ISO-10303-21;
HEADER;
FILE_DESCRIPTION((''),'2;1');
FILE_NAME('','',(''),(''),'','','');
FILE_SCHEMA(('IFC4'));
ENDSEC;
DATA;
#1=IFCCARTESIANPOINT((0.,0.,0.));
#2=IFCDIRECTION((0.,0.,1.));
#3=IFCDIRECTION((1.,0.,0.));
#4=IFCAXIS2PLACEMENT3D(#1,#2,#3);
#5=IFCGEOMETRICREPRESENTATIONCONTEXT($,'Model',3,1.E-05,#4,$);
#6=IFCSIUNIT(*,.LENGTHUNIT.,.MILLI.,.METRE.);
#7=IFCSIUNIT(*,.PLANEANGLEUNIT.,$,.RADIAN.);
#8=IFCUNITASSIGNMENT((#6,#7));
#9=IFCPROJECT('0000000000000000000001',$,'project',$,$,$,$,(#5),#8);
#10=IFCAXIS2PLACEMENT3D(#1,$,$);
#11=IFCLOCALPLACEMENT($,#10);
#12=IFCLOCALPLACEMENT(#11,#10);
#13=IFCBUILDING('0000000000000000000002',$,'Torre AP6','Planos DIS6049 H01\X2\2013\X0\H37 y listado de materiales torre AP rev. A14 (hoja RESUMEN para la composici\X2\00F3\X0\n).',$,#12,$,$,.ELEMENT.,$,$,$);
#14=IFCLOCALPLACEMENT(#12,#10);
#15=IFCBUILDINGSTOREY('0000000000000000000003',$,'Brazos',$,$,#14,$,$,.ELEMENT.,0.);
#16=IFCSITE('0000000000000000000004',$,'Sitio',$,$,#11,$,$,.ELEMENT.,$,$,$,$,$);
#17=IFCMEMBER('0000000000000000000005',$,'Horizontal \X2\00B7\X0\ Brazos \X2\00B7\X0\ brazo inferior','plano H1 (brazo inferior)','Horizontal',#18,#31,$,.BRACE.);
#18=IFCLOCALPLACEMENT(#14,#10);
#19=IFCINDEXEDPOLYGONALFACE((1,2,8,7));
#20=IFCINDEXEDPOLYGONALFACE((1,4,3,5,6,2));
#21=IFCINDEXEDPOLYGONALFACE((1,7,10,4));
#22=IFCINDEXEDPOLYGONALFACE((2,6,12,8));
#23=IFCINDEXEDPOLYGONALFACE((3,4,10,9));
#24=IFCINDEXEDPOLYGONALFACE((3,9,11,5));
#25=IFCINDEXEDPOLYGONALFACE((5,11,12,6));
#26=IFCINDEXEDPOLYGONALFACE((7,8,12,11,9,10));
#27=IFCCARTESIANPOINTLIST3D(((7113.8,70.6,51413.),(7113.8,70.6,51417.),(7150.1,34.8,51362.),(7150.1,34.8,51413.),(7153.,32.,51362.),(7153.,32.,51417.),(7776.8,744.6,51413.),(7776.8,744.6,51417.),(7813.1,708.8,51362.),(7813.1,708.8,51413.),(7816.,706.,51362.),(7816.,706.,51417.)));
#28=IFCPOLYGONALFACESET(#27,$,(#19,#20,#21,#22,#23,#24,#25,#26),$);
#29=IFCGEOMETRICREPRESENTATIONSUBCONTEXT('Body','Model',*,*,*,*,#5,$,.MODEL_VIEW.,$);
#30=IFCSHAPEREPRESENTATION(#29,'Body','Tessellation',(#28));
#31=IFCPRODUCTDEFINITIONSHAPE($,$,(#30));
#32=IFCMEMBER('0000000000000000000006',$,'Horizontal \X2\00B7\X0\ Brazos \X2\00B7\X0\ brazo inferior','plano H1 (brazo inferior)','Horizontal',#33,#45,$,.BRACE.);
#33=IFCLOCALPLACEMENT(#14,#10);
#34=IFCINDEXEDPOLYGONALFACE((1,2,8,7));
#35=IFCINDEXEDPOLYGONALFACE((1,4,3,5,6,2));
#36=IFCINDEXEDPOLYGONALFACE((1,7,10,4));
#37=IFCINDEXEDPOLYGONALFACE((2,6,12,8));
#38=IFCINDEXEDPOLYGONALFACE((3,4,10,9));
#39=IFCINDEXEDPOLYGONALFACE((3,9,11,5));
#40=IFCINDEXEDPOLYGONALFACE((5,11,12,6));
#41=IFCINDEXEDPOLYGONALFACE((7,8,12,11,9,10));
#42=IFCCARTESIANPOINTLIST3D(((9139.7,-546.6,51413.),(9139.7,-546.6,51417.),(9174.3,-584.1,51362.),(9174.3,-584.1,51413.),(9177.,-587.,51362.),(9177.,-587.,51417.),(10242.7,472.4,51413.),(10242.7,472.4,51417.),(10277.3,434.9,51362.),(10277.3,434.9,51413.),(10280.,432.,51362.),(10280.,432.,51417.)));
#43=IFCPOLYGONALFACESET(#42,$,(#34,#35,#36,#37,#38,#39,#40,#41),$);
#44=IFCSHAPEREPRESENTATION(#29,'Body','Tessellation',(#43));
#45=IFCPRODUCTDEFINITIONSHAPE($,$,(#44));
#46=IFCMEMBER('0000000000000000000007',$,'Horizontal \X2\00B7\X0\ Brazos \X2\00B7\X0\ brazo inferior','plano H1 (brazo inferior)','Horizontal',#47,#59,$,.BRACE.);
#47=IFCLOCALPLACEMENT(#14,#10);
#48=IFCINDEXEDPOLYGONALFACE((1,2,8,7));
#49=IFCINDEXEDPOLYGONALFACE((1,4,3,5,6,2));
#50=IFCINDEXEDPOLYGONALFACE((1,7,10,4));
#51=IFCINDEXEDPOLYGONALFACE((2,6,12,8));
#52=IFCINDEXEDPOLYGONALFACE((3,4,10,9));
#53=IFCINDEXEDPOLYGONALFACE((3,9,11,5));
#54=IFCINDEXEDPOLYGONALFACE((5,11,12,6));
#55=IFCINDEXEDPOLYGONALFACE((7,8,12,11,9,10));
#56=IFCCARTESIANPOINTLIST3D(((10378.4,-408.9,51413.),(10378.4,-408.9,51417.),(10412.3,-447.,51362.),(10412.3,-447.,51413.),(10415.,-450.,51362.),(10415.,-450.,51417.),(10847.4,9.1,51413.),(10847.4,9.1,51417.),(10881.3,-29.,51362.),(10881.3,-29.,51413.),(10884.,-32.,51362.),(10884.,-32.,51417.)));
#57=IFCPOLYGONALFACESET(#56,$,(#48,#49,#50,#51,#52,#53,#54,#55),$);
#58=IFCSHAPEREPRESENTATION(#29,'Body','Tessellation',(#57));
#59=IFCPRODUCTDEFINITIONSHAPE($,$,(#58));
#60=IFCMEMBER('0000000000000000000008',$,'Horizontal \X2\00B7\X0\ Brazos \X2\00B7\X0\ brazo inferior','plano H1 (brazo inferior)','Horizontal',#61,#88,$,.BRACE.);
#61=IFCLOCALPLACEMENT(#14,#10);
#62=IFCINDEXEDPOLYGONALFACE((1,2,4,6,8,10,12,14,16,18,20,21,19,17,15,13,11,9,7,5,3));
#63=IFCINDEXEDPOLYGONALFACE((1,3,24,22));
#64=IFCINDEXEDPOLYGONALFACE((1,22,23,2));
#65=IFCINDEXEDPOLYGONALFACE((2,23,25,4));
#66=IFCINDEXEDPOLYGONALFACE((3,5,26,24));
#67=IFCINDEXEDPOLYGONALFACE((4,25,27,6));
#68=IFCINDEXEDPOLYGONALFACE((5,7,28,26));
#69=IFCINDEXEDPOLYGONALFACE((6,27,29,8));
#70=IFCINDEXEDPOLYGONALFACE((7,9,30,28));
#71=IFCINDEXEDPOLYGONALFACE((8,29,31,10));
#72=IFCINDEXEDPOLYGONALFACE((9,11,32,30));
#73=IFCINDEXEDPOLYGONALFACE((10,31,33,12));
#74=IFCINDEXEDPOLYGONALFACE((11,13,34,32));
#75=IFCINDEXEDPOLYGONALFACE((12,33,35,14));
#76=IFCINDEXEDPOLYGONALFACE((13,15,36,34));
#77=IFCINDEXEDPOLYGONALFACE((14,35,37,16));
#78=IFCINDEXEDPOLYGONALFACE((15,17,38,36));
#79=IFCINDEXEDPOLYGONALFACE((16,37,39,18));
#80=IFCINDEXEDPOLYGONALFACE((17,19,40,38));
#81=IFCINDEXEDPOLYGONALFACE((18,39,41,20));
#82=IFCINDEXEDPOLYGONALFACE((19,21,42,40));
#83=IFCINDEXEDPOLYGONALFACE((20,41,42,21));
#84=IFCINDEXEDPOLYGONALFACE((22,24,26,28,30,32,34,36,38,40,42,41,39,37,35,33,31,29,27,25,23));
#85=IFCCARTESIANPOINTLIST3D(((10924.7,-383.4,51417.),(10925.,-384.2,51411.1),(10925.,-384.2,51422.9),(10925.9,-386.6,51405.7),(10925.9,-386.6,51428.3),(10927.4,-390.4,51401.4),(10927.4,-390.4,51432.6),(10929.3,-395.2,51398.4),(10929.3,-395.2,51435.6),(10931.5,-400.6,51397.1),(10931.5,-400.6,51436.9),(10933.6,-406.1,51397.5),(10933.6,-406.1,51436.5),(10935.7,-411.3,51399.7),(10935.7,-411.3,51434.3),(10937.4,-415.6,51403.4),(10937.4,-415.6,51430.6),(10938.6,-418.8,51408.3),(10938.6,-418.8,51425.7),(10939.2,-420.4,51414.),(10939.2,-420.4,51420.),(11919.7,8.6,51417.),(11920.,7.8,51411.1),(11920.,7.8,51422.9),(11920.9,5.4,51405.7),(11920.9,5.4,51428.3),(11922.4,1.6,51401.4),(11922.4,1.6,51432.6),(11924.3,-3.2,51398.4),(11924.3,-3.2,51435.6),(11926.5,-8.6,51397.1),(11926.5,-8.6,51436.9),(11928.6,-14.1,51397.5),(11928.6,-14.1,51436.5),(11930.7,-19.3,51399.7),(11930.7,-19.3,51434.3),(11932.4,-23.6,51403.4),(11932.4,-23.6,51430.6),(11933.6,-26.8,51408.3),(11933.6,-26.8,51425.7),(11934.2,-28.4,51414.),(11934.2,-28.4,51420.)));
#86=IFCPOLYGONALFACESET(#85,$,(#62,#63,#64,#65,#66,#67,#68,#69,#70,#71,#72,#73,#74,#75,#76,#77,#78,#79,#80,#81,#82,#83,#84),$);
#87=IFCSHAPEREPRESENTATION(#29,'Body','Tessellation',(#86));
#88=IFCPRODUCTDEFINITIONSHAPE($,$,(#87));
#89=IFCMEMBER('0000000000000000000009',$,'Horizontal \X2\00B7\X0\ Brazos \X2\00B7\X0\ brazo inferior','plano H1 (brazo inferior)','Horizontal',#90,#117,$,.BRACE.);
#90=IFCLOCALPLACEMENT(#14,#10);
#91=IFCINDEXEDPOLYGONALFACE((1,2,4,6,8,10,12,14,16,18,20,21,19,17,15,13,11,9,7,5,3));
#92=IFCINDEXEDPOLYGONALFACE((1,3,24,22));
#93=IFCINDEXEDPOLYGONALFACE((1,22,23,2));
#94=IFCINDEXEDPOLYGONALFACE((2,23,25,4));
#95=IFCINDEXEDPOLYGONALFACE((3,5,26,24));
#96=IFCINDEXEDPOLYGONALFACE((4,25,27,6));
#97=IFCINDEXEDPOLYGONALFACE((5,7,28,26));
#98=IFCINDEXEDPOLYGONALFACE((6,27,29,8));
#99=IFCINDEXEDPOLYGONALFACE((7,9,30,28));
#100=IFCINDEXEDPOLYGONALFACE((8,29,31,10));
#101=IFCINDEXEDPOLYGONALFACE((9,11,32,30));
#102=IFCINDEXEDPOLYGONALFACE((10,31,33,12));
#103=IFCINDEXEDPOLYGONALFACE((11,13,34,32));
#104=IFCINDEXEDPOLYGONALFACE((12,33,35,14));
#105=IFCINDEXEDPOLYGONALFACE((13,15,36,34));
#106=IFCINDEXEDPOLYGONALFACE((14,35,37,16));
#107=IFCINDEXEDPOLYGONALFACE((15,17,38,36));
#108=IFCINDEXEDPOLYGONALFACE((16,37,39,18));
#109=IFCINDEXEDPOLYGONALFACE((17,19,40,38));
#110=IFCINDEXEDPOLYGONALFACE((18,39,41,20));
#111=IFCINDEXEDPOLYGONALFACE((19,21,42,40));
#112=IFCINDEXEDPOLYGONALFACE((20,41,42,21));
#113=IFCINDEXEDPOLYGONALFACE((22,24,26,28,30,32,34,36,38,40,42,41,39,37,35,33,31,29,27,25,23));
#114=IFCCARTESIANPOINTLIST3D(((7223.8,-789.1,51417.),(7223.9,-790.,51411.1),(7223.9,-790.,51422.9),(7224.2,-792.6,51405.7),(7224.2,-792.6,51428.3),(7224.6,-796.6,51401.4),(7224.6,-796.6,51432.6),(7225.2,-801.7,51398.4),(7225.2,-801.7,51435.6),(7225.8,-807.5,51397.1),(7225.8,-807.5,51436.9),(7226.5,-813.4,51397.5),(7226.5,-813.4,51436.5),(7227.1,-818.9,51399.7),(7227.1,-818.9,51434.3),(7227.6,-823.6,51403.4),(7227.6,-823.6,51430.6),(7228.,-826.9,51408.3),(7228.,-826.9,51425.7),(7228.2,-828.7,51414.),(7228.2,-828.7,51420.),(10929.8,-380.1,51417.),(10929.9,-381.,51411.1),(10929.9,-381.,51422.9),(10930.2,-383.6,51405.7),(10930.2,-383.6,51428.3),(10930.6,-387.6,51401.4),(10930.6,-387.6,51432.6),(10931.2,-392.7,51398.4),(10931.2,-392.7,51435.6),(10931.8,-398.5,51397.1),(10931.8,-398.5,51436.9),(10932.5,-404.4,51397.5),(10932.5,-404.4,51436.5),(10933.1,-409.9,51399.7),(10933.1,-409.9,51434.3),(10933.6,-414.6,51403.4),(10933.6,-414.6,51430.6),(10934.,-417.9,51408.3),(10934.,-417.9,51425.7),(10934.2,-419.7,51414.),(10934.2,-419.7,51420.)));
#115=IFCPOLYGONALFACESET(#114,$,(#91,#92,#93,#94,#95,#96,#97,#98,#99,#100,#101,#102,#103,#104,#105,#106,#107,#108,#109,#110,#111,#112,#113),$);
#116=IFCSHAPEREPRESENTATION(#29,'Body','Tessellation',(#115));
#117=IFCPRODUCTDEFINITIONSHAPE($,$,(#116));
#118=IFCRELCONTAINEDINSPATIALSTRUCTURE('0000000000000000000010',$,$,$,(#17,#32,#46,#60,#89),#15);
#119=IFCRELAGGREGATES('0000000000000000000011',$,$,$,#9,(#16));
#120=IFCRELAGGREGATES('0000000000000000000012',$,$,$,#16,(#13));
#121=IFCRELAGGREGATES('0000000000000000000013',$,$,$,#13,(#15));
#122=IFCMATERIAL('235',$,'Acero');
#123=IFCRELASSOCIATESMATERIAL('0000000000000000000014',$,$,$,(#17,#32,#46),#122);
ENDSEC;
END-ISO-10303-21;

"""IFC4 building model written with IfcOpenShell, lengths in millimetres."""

from ifc_helpers import new_model, si_unit, frame, frame_2d, origin, origin_with_axes, place, context, subcontext, project, spatial, circle, l_section, extrude, material, element, save


model = new_model("IFC4")

# Units and contexts
model_context = context("Model", 3, precision=1e-05, world=origin_with_axes())
body_context = subcontext(model_context, "Body", "Model", "MODEL_VIEW")
ifc_project = project(units=[si_unit("LENGTHUNIT", "METRE", prefix="MILLI"), si_unit("PLANEANGLEUNIT", "RADIAN")], contexts=[model_context])

# Site, building, storey
site_placement = place(None, origin())
site = spatial("IfcSite", under=ifc_project, at=site_placement, Name="Sitio", CompositionType="ELEMENT")
building_placement = place(site_placement, origin())
building = spatial("IfcBuilding", under=site, at=building_placement, Name="Torre AP6", Description="Planos DIS6049 H01–H37 y listado de materiales torre AP rev. A14 (hoja RESUMEN para la composición).", CompositionType="ELEMENT")
storey_placement = place(building_placement, origin())
storey = spatial("IfcBuildingStorey", under=building, at=storey_placement, Name="Brazos", CompositionType="ELEMENT", Elevation=0.0)

# Members
ifc_material_1 = material(Name="235", Category="Acero")
member_1_placement = place(storey_placement, frame((7816.0, 706.0, 51417.0), z_axis=(-0.701265, -0.7129, 0.0), x_axis=(-0.7129, 0.701265, 0.0)))
element("IfcMember", 1, at=member_1_placement, inside=storey, material=ifc_material_1, Name="Horizontal · Brazos · brazo inferior", Description="plano H1 (brazo inferior)", ObjectType="Horizontal", PredefinedType="BRACE", context=body_context, shape_type="SweptSolid", body=[
    extrude(l_section(Depth=55.0, Width=55.0, Thickness=4.0, at=frame_2d((27.5, 27.5))), None, (0.0, 0.0, 1.0), 945.4),
])
member_2_placement = place(storey_placement, frame((10280.0, 432.0, 51417.0), z_axis=(-0.734523, -0.678584, 0.0), x_axis=(-0.678584, 0.734523, 0.0)))
element("IfcMember", 2, at=member_2_placement, inside=storey, material=ifc_material_1, Name="Horizontal · Brazos · brazo inferior", Description="plano H1 (brazo inferior)", ObjectType="Horizontal", PredefinedType="BRACE", context=body_context, shape_type="SweptSolid", body=[
    extrude(l_section(Depth=55.0, Width=55.0, Thickness=4.0, at=frame_2d((27.5, 27.5))), None, (0.0, 0.0, 1.0), 1501.7),
])
member_3_placement = place(storey_placement, frame((10884.0, -32.0, 51417.0), z_axis=(-0.74653, -0.665351, 0.0), x_axis=(-0.665351, 0.74653, 0.0)))
element("IfcMember", 3, at=member_3_placement, inside=storey, material=ifc_material_1, Name="Horizontal · Brazos · brazo inferior", Description="plano H1 (brazo inferior)", ObjectType="Horizontal", PredefinedType="BRACE", context=body_context, shape_type="SweptSolid", body=[
    extrude(l_section(Depth=55.0, Width=55.0, Thickness=4.0, at=frame_2d((27.5, 27.5))), None, (0.0, 0.0, 1.0), 628.2),
])
member_4_placement = place(storey_placement, frame((11927.0, -10.0, 51417.0), z_axis=(-0.930399, -0.366549, 0.0), x_axis=(-0.366549, 0.930399, 0.0)))
element("IfcMember", 4, at=member_4_placement, inside=storey, Name="Horizontal · Brazos · brazo inferior", Description="plano H1 (brazo inferior)", ObjectType="Horizontal", PredefinedType="BRACE", context=body_context, shape_type="SweptSolid", body=[
    extrude(circle(Radius=20.0), None, (0.0, 0.0, 1.0), 1069.4),
])
member_5_placement = place(storey_placement, frame((10932.0, -400.0, 51417.0), z_axis=(-0.993965, -0.109696, 0.0), x_axis=(-0.109696, 0.993965, 0.0)))
element("IfcMember", 5, at=member_5_placement, inside=storey, Name="Horizontal · Brazos · brazo inferior", Description="plano H1 (brazo inferior)", ObjectType="Horizontal", PredefinedType="BRACE", context=body_context, shape_type="SweptSolid", body=[
    extrude(circle(Radius=20.0), None, (0.0, 0.0, 1.0), 3728.5),
])

save(model, "model.ifc")
